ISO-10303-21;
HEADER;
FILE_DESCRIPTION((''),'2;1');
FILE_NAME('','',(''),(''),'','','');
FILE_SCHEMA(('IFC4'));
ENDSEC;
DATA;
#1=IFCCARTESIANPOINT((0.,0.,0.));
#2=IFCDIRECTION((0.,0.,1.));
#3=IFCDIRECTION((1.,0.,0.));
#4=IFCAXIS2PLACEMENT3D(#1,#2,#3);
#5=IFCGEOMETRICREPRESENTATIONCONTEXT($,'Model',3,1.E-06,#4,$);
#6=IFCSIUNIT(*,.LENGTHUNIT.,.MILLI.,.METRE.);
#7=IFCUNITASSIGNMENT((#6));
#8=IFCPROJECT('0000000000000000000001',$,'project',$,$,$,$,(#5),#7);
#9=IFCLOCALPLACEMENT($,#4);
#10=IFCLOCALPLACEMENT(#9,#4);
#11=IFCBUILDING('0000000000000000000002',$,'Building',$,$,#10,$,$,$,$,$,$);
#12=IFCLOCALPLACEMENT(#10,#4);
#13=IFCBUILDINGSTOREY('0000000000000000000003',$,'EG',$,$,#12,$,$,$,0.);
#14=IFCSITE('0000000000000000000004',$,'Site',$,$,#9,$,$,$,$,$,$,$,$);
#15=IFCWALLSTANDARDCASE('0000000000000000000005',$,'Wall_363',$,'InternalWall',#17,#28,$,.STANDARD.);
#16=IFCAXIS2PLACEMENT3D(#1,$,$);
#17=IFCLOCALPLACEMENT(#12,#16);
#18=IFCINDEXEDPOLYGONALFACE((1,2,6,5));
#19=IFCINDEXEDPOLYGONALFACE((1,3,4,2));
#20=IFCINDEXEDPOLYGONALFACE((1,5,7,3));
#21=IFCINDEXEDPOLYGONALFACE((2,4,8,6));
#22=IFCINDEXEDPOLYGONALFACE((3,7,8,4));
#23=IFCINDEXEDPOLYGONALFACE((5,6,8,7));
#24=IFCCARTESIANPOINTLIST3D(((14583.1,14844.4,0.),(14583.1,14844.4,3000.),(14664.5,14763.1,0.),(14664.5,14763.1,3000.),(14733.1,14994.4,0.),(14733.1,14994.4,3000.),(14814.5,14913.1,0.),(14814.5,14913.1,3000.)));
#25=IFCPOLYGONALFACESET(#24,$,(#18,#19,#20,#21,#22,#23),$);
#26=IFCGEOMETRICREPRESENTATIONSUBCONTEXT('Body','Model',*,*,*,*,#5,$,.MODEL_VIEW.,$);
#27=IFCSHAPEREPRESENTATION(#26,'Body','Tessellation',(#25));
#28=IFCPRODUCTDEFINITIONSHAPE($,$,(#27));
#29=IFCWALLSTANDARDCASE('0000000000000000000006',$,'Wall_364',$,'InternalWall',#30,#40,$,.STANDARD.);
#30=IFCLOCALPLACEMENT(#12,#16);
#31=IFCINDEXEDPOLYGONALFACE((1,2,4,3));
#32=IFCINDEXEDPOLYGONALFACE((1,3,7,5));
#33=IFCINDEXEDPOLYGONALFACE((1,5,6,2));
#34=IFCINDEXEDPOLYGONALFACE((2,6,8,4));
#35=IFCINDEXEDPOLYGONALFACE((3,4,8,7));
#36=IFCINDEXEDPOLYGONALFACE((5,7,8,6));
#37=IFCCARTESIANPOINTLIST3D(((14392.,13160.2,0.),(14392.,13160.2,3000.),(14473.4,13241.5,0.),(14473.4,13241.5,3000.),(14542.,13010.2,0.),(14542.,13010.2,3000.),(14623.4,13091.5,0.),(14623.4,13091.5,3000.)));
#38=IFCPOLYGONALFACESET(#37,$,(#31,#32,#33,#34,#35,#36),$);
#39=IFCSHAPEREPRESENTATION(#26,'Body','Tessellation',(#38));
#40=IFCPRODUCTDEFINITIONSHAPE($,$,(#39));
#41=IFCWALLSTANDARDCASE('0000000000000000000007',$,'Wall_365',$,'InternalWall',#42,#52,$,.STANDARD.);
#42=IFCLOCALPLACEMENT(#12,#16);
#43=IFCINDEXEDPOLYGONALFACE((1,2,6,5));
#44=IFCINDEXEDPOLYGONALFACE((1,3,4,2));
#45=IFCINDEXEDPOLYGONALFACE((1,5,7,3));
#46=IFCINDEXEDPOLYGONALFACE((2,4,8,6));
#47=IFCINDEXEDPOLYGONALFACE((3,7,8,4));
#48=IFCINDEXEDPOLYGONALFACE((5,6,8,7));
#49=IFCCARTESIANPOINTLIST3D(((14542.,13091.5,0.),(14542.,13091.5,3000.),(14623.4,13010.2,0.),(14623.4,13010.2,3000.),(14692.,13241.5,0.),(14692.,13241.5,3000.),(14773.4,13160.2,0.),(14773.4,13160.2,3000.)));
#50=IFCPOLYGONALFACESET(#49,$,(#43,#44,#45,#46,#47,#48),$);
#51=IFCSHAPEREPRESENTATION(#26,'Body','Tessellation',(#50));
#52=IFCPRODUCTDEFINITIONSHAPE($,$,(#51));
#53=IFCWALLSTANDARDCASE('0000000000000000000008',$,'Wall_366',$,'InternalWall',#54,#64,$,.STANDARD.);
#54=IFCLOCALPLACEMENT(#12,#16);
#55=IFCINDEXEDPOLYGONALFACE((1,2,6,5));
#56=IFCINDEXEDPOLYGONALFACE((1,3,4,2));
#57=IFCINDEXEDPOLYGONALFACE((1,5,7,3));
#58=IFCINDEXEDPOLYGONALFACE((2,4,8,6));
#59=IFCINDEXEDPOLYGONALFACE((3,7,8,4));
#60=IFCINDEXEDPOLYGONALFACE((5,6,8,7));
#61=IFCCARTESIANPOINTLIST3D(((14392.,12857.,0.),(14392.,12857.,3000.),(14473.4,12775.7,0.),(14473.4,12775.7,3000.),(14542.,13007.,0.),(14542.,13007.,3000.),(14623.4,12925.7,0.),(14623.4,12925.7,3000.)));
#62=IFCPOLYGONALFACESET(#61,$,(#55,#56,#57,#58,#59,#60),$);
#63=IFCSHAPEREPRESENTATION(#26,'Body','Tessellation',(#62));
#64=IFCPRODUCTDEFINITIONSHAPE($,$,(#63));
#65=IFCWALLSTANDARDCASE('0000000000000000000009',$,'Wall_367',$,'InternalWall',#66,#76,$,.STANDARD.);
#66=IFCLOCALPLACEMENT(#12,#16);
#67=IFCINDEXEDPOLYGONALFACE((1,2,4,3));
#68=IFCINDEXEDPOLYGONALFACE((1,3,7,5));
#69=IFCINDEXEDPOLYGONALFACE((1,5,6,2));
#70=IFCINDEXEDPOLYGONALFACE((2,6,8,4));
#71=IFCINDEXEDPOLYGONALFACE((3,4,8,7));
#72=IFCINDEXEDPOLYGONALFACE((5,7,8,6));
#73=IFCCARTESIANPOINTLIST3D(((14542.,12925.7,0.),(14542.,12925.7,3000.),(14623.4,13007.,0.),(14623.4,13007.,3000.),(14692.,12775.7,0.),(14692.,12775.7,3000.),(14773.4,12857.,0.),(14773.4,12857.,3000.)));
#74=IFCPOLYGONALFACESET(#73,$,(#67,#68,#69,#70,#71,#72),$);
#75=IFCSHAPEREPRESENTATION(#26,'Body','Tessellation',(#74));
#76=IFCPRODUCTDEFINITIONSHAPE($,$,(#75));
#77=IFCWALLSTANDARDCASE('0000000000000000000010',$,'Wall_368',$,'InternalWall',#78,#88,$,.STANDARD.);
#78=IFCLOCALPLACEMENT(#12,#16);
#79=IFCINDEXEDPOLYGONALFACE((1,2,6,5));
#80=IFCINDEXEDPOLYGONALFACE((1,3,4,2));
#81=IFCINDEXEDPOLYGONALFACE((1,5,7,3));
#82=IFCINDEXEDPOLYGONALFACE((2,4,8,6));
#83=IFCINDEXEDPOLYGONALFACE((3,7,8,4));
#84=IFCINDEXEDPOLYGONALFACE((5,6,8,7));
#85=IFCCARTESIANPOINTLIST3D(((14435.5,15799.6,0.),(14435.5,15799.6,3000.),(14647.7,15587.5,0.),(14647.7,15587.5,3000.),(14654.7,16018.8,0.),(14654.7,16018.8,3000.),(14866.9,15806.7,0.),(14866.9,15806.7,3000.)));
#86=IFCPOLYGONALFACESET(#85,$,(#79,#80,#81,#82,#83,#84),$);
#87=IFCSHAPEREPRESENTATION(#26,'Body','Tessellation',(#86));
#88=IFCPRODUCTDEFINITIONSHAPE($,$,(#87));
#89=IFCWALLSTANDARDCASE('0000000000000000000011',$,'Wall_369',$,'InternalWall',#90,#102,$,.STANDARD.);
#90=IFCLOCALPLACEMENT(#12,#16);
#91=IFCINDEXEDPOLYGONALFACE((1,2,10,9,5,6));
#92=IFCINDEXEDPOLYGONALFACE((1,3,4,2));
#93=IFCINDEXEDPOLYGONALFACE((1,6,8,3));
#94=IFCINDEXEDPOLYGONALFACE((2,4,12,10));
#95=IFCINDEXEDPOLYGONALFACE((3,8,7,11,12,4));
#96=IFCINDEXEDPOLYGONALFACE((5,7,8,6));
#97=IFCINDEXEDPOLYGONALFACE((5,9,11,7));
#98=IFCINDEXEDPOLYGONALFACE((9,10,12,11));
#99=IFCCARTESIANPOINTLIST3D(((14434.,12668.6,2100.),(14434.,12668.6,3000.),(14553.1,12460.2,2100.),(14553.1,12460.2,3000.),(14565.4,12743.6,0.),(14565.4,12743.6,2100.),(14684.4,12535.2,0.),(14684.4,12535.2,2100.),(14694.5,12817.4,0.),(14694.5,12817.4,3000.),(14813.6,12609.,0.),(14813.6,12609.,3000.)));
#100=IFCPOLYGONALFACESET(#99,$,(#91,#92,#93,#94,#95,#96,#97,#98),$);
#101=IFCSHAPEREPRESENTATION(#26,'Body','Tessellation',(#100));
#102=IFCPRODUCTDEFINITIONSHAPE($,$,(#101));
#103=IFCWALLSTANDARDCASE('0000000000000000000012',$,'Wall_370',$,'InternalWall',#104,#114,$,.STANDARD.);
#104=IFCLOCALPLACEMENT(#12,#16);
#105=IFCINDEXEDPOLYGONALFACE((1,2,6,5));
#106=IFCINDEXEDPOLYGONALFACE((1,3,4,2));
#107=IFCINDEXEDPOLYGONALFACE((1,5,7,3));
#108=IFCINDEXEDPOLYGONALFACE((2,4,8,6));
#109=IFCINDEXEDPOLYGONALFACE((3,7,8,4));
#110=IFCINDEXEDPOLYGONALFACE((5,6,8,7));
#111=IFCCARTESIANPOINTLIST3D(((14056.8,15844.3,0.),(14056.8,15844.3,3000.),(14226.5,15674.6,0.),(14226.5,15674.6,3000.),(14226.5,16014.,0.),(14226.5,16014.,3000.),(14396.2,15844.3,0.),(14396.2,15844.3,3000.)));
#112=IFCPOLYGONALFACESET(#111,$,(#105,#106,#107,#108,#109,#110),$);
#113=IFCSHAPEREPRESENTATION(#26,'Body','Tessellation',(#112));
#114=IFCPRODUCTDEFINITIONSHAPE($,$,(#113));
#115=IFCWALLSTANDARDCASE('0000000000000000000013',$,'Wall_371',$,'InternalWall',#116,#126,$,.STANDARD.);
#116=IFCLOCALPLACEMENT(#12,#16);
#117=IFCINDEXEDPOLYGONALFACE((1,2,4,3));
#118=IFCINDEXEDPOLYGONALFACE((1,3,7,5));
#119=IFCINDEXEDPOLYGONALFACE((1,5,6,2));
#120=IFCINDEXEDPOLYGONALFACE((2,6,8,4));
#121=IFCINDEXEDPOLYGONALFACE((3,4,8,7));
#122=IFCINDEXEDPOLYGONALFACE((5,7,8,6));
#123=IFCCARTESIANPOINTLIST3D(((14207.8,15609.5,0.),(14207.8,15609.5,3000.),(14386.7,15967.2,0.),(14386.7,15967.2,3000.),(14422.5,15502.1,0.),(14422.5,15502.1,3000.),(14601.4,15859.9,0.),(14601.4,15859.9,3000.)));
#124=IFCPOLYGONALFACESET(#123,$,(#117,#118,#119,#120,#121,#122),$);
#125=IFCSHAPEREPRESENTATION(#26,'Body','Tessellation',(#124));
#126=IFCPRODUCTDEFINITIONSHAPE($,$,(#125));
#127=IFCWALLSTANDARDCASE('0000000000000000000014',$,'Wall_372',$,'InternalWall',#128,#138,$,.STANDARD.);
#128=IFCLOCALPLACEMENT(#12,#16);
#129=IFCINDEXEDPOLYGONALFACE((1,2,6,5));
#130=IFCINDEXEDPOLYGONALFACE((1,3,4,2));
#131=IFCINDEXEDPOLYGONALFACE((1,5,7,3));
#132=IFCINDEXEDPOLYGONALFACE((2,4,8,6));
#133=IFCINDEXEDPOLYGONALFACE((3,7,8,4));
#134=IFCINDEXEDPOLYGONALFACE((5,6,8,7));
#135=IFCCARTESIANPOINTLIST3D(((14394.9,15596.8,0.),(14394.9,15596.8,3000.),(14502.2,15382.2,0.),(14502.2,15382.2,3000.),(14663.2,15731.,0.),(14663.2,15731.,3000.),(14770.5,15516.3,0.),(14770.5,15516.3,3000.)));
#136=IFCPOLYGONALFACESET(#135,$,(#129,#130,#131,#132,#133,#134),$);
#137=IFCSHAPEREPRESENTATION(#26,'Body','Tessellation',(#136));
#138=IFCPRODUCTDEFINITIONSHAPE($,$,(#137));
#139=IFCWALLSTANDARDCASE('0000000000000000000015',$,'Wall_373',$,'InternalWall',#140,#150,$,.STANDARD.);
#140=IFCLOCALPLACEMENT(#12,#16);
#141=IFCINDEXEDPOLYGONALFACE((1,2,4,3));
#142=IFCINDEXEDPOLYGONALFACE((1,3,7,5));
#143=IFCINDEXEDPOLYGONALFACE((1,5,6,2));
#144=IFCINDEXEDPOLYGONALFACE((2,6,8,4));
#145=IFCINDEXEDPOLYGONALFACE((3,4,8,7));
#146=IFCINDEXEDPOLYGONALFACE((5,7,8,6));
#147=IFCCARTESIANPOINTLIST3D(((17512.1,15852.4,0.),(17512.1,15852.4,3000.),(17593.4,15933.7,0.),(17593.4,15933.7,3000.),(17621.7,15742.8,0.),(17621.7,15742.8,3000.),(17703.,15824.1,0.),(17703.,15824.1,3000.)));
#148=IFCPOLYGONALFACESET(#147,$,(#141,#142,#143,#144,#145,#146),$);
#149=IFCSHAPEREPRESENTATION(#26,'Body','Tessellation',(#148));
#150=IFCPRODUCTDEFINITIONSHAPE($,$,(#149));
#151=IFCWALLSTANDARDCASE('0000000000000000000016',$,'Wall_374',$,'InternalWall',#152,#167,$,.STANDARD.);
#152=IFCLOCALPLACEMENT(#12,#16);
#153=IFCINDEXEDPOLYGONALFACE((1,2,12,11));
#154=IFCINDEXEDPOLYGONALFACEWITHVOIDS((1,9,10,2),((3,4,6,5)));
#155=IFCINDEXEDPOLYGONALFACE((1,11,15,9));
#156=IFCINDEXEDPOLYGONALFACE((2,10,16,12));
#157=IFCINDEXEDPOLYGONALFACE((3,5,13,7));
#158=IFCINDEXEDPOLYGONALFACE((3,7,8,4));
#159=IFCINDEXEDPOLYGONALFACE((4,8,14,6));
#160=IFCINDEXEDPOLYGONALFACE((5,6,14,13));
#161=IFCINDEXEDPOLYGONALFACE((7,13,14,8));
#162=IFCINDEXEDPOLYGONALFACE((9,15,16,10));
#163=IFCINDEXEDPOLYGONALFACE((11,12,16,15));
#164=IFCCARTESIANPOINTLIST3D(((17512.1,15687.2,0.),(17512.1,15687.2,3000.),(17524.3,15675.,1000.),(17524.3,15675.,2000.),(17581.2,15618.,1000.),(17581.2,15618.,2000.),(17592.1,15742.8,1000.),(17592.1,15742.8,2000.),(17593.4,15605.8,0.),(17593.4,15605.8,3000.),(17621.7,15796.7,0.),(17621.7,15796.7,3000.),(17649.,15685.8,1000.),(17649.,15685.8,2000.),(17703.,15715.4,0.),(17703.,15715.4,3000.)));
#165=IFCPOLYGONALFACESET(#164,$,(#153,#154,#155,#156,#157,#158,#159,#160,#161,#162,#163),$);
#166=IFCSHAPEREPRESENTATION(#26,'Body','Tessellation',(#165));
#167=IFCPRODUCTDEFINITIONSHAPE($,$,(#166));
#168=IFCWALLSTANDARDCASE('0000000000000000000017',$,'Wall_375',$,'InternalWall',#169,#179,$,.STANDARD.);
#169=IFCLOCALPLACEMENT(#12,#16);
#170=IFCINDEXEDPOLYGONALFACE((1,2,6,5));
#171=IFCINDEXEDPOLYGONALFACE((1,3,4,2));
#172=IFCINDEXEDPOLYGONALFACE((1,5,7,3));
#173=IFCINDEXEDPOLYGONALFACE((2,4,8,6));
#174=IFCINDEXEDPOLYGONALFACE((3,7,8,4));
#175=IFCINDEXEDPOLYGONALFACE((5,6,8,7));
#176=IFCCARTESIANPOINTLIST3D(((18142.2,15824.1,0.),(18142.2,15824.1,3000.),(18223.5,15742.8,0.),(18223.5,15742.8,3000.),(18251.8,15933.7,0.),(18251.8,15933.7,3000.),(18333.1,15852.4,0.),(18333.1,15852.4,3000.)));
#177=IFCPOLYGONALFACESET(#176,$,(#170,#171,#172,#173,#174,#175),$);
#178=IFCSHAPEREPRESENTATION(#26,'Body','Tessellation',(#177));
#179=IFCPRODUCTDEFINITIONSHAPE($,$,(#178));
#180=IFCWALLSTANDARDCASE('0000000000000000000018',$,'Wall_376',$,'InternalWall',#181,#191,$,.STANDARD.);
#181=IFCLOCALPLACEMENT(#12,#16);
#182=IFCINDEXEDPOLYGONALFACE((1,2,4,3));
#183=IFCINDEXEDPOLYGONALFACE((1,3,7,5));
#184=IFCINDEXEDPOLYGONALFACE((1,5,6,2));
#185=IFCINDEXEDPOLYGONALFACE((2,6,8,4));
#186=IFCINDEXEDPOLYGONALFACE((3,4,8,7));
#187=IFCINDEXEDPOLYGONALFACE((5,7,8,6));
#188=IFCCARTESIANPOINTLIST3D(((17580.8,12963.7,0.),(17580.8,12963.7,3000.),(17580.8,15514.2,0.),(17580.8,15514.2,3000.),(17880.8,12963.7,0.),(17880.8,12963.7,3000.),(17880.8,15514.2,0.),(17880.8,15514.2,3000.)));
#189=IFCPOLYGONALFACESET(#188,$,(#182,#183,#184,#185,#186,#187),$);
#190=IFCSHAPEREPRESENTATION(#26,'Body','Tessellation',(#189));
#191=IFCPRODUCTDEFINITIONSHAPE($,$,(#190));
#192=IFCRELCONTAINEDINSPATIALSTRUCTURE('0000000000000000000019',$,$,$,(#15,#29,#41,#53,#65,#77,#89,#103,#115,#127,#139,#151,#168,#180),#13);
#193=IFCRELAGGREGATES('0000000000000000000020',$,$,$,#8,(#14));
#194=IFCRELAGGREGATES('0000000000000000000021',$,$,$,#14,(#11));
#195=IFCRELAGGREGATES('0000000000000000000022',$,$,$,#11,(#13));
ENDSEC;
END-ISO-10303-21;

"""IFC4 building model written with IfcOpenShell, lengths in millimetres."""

from ifc_helpers import new_model, si_unit, frame, origin_with_axes, place, context, subcontext, project, spatial, rectangle, extrude, element, save


model = new_model("IFC4")

# Units and contexts
model_context = context("Model", 3, precision=1e-06, world=origin_with_axes())
body_context = subcontext(model_context, "Body", "Model", "MODEL_VIEW")
ifc_project = project(units=[si_unit("LENGTHUNIT", "METRE", prefix="MILLI")], contexts=[model_context])

# Site, building, storey
site_placement = place(None, origin_with_axes())
site = spatial("IfcSite", under=ifc_project, at=site_placement, Name="Site")
building_placement = place(site_placement, origin_with_axes())
building = spatial("IfcBuilding", under=site, at=building_placement, Name="Building")
storey_placement = place(building_placement, origin_with_axes())
storey = spatial("IfcBuildingStorey", under=building, at=storey_placement, Name="EG", Elevation=0.0)

# Walls
wall_1_placement = place(storey_placement, origin_with_axes())
element("IfcWallStandardCase", 1, at=wall_1_placement, inside=storey, Name="Wall_363", ObjectType="InternalWall", PredefinedType="STANDARD", context=body_context, shape_type="SweptSolid", body=[
    extrude(rectangle(XDim=212.1, YDim=115.0), frame((14698.8, 14878.7, 0.0), z_axis=(0.0, 0.0, 1.0), x_axis=(0.707107, 0.707107, 0.0)), (0.0, 0.0, 1.0), 3000.0),
])
wall_2_placement = place(storey_placement, origin_with_axes())
element("IfcWallStandardCase", 2, at=wall_2_placement, inside=storey, Name="Wall_364", ObjectType="InternalWall", PredefinedType="STANDARD", context=body_context, shape_type="SweptSolid", body=[
    extrude(rectangle(XDim=212.1, YDim=115.0), frame((14507.7, 13125.9, 0.0), z_axis=(0.0, 0.0, 1.0), x_axis=(0.707107, -0.707107, 0.0)), (0.0, 0.0, 1.0), 3000.0),
])
wall_3_placement = place(storey_placement, origin_with_axes())
element("IfcWallStandardCase", 3, at=wall_3_placement, inside=storey, Name="Wall_365", ObjectType="InternalWall", PredefinedType="STANDARD", context=body_context, shape_type="SweptSolid", body=[
    extrude(rectangle(XDim=212.1, YDim=115.0), frame((14657.7, 13125.9, 0.0), z_axis=(0.0, 0.0, 1.0), x_axis=(0.707107, 0.707107, 0.0)), (0.0, 0.0, 1.0), 3000.0),
])
wall_4_placement = place(storey_placement, origin_with_axes())
element("IfcWallStandardCase", 4, at=wall_4_placement, inside=storey, Name="Wall_366", ObjectType="InternalWall", PredefinedType="STANDARD", context=body_context, shape_type="SweptSolid", body=[
    extrude(rectangle(XDim=212.1, YDim=115.0), frame((14507.7, 12891.4, 0.0), z_axis=(0.0, 0.0, 1.0), x_axis=(-0.707107, -0.707107, 0.0)), (0.0, 0.0, 1.0), 3000.0),
])
wall_5_placement = place(storey_placement, origin_with_axes())
element("IfcWallStandardCase", 5, at=wall_5_placement, inside=storey, Name="Wall_367", ObjectType="InternalWall", PredefinedType="STANDARD", context=body_context, shape_type="SweptSolid", body=[
    extrude(rectangle(XDim=212.1, YDim=115.0), frame((14657.7, 12891.4, 0.0), z_axis=(0.0, 0.0, 1.0), x_axis=(0.707107, -0.707107, 0.0)), (0.0, 0.0, 1.0), 3000.0),
])
wall_6_placement = place(storey_placement, origin_with_axes())
element("IfcWallStandardCase", 6, at=wall_6_placement, inside=storey, Name="Wall_368", ObjectType="InternalWall", PredefinedType="STANDARD", context=body_context, shape_type="SweptSolid", body=[
    extrude(rectangle(XDim=310.0, YDim=300.0), frame((14651.2, 15803.2, 0.0), z_axis=(0.0, 0.0, 1.0), x_axis=(-0.707107, -0.707107, 0.0)), (0.0, 0.0, 1.0), 3000.0),
])

# Wall, opening
wall_7_placement = place(storey_placement, origin_with_axes())
wall_7 = element("IfcWallStandardCase", 7, at=wall_7_placement, inside=storey, Name="Wall_369", ObjectType="InternalWall", PredefinedType="STANDARD", context=body_context, shape_type="SweptSolid", body=[
    extrude(rectangle(XDim=300.0, YDim=240.0), frame((14623.8, 12638.8, 0.0), z_axis=(0.0, 0.0, 1.0), x_axis=(0.868243, 0.496139, 0.0)), (0.0, 0.0, 1.0), 3000.0),
])
opening_1_placement = place(wall_7_placement, origin_with_axes())
element("IfcOpeningElement", 8, at=opening_1_placement, inside=storey, cuts=wall_7, context=body_context, shape_type="SweptSolid", body=[
    extrude(rectangle(XDim=1074.2, YDim=240.0), frame((14158.6, 12372.9, 0.0), z_axis=(0.0, 0.0, 1.0), x_axis=(0.868243, 0.496139, 0.0)), (0.0, 0.0, 1.0), 2100.0),
])

# Walls
wall_8_placement = place(storey_placement, origin_with_axes())
element("IfcWallStandardCase", 9, at=wall_8_placement, inside=storey, Name="Wall_370", ObjectType="InternalWall", PredefinedType="STANDARD", context=body_context, shape_type="SweptSolid", body=[
    extrude(rectangle(XDim=240.0, YDim=240.0), frame((14226.5, 15844.3, 0.0), z_axis=(0.0, 0.0, 1.0), x_axis=(0.707107, 0.707107, 0.0)), (0.0, 0.0, 1.0), 3000.0),
])
wall_9_placement = place(storey_placement, origin_with_axes())
element("IfcWallStandardCase", 10, at=wall_9_placement, inside=storey, Name="Wall_371", ObjectType="InternalWall", PredefinedType="STANDARD", context=body_context, shape_type="SweptSolid", body=[
    extrude(rectangle(XDim=400.0, YDim=240.0), frame((14404.6, 15734.7, 0.0), z_axis=(0.0, 0.0, 1.0), x_axis=(0.447214, 0.894427, 0.0)), (0.0, 0.0, 1.0), 3000.0),
])
wall_10_placement = place(storey_placement, origin_with_axes())
element("IfcWallStandardCase", 11, at=wall_10_placement, inside=storey, Name="Wall_372", ObjectType="InternalWall", PredefinedType="STANDARD", context=body_context, shape_type="SweptSolid", body=[
    extrude(rectangle(XDim=300.0, YDim=240.0), frame((14582.7, 15556.6, 0.0), z_axis=(0.0, 0.0, 1.0), x_axis=(-0.894427, -0.447214, 0.0)), (0.0, 0.0, 1.0), 3000.0),
])
wall_11_placement = place(storey_placement, origin_with_axes())
element("IfcWallStandardCase", 12, at=wall_11_placement, inside=storey, Name="Wall_373", ObjectType="InternalWall", PredefinedType="STANDARD", context=body_context, shape_type="SweptSolid", body=[
    extrude(rectangle(XDim=155.0, YDim=115.0), frame((17607.5, 15838.3, 0.0), z_axis=(0.0, 0.0, 1.0), x_axis=(-0.707107, 0.707107, 0.0)), (0.0, 0.0, 1.0), 3000.0),
])

# Wall, opening
wall_12_placement = place(storey_placement, origin_with_axes())
wall_12 = element("IfcWallStandardCase", 13, at=wall_12_placement, inside=storey, Name="Wall_374", ObjectType="InternalWall", PredefinedType="STANDARD", context=body_context, shape_type="SweptSolid", body=[
    extrude(rectangle(XDim=155.0, YDim=115.0), frame((17607.5, 15701.3, 0.0), z_axis=(0.0, 0.0, 1.0), x_axis=(0.707107, 0.707107, 0.0)), (0.0, 0.0, 1.0), 3000.0),
])
opening_2_placement = place(wall_12_placement, origin_with_axes())
element("IfcOpeningElement", 14, at=opening_2_placement, inside=storey, cuts=wall_12, context=body_context, shape_type="SweptSolid", body=[
    extrude(rectangle(XDim=796.2, YDim=80.5), frame((17339.0, 15432.8, 1000.0), z_axis=(0.0, 0.0, 1.0), x_axis=(0.707107, 0.707107, 0.0)), (0.0, 0.0, 1.0), 1000.0),
])

# Walls
wall_13_placement = place(storey_placement, origin_with_axes())
element("IfcWallStandardCase", 15, at=wall_13_placement, inside=storey, Name="Wall_375", ObjectType="InternalWall", PredefinedType="STANDARD", context=body_context, shape_type="SweptSolid", body=[
    extrude(rectangle(XDim=155.0, YDim=115.0), frame((18237.7, 15838.3, 0.0), z_axis=(0.0, 0.0, 1.0), x_axis=(-0.707107, -0.707107, 0.0)), (0.0, 0.0, 1.0), 3000.0),
])
wall_14_placement = place(storey_placement, origin_with_axes())
element("IfcWallStandardCase", 16, at=wall_14_placement, inside=storey, Name="Wall_376", ObjectType="InternalWall", PredefinedType="STANDARD", context=body_context, shape_type="SweptSolid", body=[
    extrude(rectangle(XDim=2550.5, YDim=300.0), frame((17730.8, 14239.0, 0.0), z_axis=(0.0, 0.0, 1.0), x_axis=(0.0, -1.0, 0.0)), (0.0, 0.0, 1.0), 3000.0),
])

save(model, "model.ifc")
